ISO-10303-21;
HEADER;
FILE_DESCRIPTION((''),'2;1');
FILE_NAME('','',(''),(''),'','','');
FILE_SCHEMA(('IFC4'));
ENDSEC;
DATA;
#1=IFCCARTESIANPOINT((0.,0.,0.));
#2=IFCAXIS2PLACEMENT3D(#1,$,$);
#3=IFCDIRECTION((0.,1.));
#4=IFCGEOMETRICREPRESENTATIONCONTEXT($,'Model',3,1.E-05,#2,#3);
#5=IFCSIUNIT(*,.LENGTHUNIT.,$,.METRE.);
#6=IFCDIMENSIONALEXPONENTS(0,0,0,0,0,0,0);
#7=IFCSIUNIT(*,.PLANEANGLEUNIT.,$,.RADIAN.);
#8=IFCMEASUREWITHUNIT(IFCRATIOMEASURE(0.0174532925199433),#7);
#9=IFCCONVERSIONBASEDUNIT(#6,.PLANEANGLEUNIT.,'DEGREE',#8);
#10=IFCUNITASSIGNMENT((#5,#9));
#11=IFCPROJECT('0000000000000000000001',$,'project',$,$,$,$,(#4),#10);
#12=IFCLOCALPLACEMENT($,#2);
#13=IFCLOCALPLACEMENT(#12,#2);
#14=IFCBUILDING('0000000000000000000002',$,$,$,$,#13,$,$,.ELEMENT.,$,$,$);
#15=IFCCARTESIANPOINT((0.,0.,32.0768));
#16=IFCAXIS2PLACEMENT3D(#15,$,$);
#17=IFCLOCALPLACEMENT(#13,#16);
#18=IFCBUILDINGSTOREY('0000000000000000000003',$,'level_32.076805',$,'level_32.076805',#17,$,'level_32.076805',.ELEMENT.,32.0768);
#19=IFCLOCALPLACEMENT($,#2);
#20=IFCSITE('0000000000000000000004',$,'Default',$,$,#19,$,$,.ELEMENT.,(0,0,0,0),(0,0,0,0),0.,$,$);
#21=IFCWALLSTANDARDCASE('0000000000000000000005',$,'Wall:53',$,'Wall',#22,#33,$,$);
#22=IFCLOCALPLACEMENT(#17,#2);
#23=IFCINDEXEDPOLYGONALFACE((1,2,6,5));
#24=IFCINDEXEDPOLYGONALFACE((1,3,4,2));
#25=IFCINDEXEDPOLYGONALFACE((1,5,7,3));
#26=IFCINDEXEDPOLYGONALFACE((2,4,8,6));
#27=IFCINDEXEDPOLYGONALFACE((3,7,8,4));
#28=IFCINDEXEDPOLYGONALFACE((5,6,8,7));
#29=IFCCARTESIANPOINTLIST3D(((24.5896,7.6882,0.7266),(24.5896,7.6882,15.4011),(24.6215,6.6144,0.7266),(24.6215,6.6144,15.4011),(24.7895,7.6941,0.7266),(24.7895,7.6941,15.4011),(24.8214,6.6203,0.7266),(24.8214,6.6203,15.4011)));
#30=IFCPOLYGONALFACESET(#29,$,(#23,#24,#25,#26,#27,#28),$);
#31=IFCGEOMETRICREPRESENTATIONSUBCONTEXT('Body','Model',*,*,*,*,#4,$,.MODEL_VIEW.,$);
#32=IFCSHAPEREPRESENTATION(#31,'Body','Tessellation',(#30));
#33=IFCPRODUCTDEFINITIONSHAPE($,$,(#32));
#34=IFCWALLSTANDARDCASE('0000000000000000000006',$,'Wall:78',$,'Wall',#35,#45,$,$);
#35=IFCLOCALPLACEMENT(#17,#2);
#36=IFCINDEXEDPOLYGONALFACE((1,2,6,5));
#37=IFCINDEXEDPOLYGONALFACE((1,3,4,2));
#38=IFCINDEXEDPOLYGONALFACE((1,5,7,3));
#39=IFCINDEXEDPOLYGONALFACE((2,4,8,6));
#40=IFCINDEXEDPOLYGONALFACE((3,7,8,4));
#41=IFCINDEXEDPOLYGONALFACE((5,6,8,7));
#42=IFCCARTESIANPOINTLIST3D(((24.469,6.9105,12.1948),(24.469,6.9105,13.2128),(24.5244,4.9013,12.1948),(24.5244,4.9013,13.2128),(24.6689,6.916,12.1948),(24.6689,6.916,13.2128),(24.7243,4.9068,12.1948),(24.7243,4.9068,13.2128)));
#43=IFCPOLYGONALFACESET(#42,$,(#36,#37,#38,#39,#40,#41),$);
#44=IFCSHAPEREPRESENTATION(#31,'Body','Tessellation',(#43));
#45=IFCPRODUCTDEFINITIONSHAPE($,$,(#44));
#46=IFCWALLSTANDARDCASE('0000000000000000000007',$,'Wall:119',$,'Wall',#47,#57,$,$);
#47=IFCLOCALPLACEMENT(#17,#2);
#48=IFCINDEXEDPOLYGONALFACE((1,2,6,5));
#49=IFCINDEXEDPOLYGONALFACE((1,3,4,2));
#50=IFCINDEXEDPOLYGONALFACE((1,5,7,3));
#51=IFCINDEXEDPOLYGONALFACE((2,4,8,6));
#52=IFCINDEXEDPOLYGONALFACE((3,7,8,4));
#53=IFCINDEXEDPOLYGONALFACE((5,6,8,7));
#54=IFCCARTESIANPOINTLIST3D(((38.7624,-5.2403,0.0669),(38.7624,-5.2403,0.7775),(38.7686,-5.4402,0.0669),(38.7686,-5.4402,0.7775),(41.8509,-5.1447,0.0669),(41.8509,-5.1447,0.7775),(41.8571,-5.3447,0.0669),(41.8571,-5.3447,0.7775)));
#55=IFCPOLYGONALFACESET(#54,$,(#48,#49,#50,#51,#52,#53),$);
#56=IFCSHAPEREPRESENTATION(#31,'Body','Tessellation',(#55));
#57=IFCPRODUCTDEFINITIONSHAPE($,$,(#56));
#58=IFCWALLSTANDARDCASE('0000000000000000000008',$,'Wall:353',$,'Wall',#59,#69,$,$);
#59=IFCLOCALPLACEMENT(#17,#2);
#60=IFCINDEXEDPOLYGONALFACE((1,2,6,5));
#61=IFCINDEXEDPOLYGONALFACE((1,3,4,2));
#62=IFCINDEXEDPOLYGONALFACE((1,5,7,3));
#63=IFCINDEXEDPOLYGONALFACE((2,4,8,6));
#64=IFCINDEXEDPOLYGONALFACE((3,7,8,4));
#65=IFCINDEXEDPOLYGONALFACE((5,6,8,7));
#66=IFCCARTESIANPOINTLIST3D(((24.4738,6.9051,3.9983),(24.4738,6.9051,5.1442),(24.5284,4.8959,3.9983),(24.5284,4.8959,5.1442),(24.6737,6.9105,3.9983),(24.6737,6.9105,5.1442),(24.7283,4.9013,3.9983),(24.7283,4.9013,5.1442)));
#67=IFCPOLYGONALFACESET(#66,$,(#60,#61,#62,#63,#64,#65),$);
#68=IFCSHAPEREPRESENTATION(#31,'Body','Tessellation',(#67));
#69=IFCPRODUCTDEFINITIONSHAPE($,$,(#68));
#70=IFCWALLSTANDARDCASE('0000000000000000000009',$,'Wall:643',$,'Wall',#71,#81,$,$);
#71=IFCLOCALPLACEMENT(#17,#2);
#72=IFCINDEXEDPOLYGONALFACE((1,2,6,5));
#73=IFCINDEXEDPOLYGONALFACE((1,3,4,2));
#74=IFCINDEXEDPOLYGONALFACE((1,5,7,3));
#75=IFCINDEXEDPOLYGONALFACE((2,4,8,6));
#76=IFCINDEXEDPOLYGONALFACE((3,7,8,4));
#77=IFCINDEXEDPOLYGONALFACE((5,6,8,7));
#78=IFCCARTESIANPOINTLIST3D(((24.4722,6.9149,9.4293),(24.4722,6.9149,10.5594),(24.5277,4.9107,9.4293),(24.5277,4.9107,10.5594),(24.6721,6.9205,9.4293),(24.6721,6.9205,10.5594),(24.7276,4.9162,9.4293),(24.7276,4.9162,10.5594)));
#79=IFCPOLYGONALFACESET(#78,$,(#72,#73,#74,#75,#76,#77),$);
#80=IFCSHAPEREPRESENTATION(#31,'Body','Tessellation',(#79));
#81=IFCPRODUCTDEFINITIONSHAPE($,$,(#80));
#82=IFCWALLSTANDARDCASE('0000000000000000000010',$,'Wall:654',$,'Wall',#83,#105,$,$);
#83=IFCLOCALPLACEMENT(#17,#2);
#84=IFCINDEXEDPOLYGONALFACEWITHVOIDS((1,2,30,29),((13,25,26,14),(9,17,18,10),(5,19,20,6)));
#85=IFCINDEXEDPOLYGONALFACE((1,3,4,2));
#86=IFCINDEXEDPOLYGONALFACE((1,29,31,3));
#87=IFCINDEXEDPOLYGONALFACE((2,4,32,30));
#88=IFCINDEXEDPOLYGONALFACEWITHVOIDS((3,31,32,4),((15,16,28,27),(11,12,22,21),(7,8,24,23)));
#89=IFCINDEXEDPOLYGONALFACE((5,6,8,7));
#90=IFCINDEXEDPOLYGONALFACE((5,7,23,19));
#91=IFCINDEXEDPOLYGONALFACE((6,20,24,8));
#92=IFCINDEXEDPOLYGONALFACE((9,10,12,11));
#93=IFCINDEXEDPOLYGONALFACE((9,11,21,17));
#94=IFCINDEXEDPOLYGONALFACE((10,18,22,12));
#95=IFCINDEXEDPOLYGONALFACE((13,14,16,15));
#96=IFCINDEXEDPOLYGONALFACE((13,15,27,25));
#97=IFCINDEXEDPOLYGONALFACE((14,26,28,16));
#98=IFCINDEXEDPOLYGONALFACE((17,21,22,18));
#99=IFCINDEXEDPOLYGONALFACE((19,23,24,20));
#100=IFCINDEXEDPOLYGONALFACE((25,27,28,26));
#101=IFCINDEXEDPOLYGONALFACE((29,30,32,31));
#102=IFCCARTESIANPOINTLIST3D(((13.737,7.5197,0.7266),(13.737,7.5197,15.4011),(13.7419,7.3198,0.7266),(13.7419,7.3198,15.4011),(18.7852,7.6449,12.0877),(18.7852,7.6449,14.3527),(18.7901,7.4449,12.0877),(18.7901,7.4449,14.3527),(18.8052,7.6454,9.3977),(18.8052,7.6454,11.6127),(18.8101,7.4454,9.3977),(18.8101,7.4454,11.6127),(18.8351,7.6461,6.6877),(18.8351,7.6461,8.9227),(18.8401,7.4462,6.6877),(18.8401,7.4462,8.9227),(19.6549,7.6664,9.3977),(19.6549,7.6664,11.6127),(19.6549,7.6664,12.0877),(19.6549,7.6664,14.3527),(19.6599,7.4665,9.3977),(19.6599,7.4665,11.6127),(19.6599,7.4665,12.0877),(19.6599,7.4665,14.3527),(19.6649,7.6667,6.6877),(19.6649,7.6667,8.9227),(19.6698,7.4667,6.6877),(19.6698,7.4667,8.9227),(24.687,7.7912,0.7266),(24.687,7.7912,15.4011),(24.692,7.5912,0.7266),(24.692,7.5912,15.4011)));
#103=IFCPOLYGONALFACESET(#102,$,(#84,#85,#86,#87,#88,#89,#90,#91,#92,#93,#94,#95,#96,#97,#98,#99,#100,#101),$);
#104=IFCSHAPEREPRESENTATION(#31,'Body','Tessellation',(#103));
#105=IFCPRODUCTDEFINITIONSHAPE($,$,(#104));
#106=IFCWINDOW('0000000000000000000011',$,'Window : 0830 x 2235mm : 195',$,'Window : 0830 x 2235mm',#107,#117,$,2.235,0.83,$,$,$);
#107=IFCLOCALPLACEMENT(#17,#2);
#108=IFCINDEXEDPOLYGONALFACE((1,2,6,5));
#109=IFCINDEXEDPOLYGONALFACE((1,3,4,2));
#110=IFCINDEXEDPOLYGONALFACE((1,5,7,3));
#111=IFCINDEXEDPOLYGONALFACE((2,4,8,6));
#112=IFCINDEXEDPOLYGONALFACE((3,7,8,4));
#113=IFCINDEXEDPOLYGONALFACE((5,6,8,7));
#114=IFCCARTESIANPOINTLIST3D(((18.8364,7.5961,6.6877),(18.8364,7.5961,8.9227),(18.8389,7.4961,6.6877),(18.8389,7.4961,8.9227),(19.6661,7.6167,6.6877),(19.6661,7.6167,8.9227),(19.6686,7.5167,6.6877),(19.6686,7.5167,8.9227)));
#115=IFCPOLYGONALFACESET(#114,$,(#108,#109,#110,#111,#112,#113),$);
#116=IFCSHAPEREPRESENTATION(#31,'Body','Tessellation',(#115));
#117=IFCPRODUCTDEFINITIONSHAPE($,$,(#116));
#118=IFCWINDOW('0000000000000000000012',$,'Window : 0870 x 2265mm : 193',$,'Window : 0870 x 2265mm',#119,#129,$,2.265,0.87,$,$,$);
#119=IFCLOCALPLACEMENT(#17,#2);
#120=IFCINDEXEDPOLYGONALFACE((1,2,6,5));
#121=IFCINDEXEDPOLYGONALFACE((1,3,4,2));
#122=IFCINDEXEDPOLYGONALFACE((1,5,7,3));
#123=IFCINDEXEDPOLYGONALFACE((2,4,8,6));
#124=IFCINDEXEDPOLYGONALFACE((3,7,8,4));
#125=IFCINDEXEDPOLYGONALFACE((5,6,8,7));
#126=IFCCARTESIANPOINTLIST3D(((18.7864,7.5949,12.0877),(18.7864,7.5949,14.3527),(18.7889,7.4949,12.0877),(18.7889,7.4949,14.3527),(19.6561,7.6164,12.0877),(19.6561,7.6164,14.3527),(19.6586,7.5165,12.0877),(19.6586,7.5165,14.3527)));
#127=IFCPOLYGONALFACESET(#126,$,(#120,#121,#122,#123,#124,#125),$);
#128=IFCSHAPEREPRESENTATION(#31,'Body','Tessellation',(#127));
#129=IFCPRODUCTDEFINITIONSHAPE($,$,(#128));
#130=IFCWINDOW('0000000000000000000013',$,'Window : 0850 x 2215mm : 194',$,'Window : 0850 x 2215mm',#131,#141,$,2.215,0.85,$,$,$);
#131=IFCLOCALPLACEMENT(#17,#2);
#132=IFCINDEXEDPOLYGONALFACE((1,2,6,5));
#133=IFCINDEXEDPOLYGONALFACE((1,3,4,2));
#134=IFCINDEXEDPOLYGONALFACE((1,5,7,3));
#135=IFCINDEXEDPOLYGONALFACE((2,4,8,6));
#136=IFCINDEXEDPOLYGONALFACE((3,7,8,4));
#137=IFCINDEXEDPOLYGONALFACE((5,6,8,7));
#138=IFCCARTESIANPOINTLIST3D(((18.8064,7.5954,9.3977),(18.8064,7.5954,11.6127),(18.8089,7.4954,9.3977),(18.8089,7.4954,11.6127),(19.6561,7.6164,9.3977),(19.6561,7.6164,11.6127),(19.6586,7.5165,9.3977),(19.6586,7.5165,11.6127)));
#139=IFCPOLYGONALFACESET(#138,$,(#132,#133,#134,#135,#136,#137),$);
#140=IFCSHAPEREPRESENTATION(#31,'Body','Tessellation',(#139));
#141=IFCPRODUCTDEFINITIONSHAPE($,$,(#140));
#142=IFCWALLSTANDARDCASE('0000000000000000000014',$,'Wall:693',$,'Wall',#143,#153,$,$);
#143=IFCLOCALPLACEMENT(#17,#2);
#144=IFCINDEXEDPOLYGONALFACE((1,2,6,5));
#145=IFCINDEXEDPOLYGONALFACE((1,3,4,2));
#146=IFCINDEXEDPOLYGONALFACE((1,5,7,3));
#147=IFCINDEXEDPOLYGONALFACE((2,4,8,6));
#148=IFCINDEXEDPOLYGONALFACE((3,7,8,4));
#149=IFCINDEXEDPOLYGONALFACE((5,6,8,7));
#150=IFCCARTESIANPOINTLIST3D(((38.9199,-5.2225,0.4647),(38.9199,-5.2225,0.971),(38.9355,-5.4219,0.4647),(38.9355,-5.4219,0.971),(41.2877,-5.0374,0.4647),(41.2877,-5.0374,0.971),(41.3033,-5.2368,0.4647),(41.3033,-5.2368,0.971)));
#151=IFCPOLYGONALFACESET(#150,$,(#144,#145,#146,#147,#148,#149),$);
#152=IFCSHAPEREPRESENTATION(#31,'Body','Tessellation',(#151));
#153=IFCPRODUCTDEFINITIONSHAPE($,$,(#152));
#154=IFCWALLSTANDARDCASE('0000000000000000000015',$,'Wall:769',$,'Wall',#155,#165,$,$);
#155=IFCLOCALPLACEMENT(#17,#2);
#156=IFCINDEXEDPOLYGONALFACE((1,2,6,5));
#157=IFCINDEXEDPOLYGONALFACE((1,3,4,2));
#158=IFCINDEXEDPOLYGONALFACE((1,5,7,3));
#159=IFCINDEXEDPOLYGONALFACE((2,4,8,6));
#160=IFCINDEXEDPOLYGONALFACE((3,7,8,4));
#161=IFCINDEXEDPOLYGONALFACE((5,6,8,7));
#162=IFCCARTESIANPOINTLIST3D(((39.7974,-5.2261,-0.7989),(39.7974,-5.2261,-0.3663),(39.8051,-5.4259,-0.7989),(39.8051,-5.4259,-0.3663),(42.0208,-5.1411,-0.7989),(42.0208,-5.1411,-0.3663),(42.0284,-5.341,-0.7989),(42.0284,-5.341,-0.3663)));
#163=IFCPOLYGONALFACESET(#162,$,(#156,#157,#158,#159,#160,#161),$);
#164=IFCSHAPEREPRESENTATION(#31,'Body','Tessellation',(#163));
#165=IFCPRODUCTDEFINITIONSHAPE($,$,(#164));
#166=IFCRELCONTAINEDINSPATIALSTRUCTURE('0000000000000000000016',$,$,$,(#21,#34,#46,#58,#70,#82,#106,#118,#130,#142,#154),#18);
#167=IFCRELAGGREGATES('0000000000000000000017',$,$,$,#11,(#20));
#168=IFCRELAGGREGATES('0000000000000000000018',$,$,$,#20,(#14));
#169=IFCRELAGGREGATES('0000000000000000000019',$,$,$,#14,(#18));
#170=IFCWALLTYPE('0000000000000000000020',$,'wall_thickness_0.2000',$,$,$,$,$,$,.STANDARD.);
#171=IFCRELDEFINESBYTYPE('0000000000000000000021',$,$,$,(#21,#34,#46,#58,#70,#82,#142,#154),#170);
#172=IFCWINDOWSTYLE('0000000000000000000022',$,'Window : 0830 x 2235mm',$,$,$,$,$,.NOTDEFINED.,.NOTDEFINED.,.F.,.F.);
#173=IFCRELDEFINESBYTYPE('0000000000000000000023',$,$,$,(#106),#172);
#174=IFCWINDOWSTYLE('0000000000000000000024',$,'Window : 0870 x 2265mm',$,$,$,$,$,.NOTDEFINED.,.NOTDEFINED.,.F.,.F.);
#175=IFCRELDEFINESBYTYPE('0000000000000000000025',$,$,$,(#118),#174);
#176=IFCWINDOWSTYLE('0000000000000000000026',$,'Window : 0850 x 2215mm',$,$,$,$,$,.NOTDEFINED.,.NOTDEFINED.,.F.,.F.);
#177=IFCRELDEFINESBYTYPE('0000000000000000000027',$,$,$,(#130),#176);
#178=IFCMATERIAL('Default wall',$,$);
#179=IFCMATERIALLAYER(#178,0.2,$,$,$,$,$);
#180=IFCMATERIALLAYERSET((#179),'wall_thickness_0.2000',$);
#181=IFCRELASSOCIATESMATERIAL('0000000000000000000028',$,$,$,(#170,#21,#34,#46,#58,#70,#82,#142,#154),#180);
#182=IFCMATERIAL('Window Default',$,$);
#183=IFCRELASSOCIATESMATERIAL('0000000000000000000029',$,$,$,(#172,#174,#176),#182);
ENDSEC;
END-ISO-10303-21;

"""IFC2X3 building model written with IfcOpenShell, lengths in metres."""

from ifc_helpers import new_model, entity, si_unit, converted_unit, direction, frame, frame_2d, origin, origin_2d_with_axis, place, context, subcontext, project, spatial, polyline, rectangle, outline, extrude, source, transform, mapped, material, layer, layer_set, layer_usage, type_object, type_shapes, element, fill, save


model = new_model("IFC2X3")

# Units and contexts
model_context = context("Model", 3, precision=1e-05, world=origin(), true_north=direction((0.0, 1.0)))
body_context = subcontext(model_context, "Body", "Model", "MODEL_VIEW")
ifc_project = project(units=[si_unit("LENGTHUNIT", "METRE"), converted_unit("PLANEANGLEUNIT", "DEGREE", entity("IfcRatioMeasure", 0.0174532925199433), si_unit("PLANEANGLEUNIT", "RADIAN"), dimensions=[0, 0, 0, 0, 0, 0, 0])], contexts=[model_context])

# Site, building, storey
site_placement = place(None, origin())
site = spatial("IfcSite", under=ifc_project, at=site_placement, Name="Default", CompositionType="ELEMENT", RefLatitude=(0, 0, 0, 0), RefLongitude=(0, 0, 0, 0), RefElevation=0.0)
placement_1 = place(None, origin())
building_placement = place(placement_1, origin())
building = spatial("IfcBuilding", under=site, at=building_placement, CompositionType="ELEMENT")
storey_placement = place(building_placement, frame((0.0, 0.0, 32.0768)))
storey = spatial("IfcBuildingStorey", under=building, at=storey_placement, Name="level_32.076805", ObjectType="level_32.076805", LongName="level_32.076805", CompositionType="ELEMENT", Elevation=32.0768)

# Walls
ifc_material_1 = material(Name="Default wall")
ifc_layer = layer(ifc_material_1, 0.2)
ifc_layer_set = layer_set([ifc_layer], Name="wall_thickness_0.2000")
ifc_layer_usage = layer_usage(ifc_layer_set, "AXIS2", "POSITIVE", -0.1)
wall_type = type_object("IfcWallType", Name="wall_thickness_0.2000", PredefinedType="STANDARD", material=ifc_layer_set)
placement_2 = place(building_placement, frame((0.0, 0.0, 32.8034)))
wall_1_placement = place(placement_2, frame((24.6895, 7.6912, 0.0), z_axis=(0.0, 0.0, 1.0), x_axis=(0.029685, -0.999559, 0.0)))
element("IfcWallStandardCase", 1, at=wall_1_placement, inside=storey, type_object=wall_type, material=ifc_layer_usage, Name="Wall:53", ObjectType="Wall", context=body_context, shape_type="SweptSolid", body=[
    extrude(outline(polyline([(1.0743, -0.1), (1.0743, 0.1), (0.0, 0.1), (0.0, -0.1), (1.0743, -0.1)])), origin(), (0.0, 0.0, 1.0), 14.6745),
])
placement_3 = place(building_placement, frame((0.0, 0.0, 44.2716)))
wall_2_placement = place(placement_3, frame((24.6244, 4.904, 0.0), z_axis=(0.0, 0.0, 1.0), x_axis=(-0.027582, 0.99962, 0.0)))
element("IfcWallStandardCase", 2, at=wall_2_placement, inside=storey, type_object=wall_type, material=ifc_layer_usage, Name="Wall:78", ObjectType="Wall", context=body_context, shape_type="SweptSolid", body=[
    extrude(outline(polyline([(2.01, -0.1), (2.01, 0.1), (0.0, 0.1), (0.0, -0.1), (2.01, -0.1)])), origin(), (0.0, 0.0, 1.0), 1.018),
])
placement_4 = place(building_placement, frame((0.0, 0.0, 32.1437)))
wall_3_placement = place(placement_4, frame((38.7655, -5.3403, 0.0), z_axis=(0.0, 0.0, 1.0), x_axis=(0.999522, 0.030931, 0.0)))
element("IfcWallStandardCase", 3, at=wall_3_placement, inside=storey, type_object=wall_type, material=ifc_layer_usage, Name="Wall:119", ObjectType="Wall", context=body_context, shape_type="SweptSolid", body=[
    extrude(outline(polyline([(3.09, -0.1), (3.09, 0.1), (0.0, 0.1), (0.0, -0.1), (3.09, -0.1)])), origin(), (0.0, 0.0, 1.0), 0.7106),
])
placement_5 = place(building_placement, frame((0.0, 0.0, 36.0751)))
wall_4_placement = place(placement_5, frame((24.6283, 4.8986, 0.0), z_axis=(0.0, 0.0, 1.0), x_axis=(-0.027138, 0.999632, 0.0)))
element("IfcWallStandardCase", 4, at=wall_4_placement, inside=storey, type_object=wall_type, material=ifc_layer_usage, Name="Wall:353", ObjectType="Wall", context=body_context, shape_type="SweptSolid", body=[
    extrude(outline(polyline([(2.01, -0.1), (2.01, 0.1), (0.0, 0.1), (0.0, -0.1), (2.01, -0.1)])), origin(), (0.0, 0.0, 1.0), 1.1459),
])
placement_6 = place(building_placement, frame((0.0, 0.0, 41.5061)))
wall_5_placement = place(placement_6, frame((24.6277, 4.9135, 0.0), z_axis=(0.0, 0.0, 1.0), x_axis=(-0.027697, 0.999616, 0.0)))
element("IfcWallStandardCase", 5, at=wall_5_placement, inside=storey, type_object=wall_type, material=ifc_layer_usage, Name="Wall:643", ObjectType="Wall", context=body_context, shape_type="SweptSolid", body=[
    extrude(outline(polyline([(2.005, -0.1), (2.005, 0.1), (0.0, 0.1), (0.0, -0.1), (2.005, -0.1)])), origin(), (0.0, 0.0, 1.0), 1.1301),
])

# Wall, openings, windows
placement_7 = place(building_placement, frame((0.0, 0.0, 32.8034)))
wall_6_placement = place(placement_7, frame((24.6895, 7.6912, 0.0), z_axis=(0.0, 0.0, 1.0), x_axis=(-0.999693, -0.024779, 0.0)))
wall_6 = element("IfcWallStandardCase", 6, at=wall_6_placement, inside=storey, type_object=wall_type, material=ifc_layer_usage, Name="Wall:654", ObjectType="Wall", context=body_context, shape_type="SweptSolid", body=[
    extrude(outline(polyline([(10.9534, -0.1), (10.9534, 0.1), (0.0, 0.1), (0.0, -0.1), (10.9534, -0.1)])), origin(), (0.0, 0.0, 1.0), 14.6745),
])
opening_1_placement = place(wall_6_placement, frame((5.0337, -0.1, 11.3611)))
opening_1 = element("IfcOpeningElement", 7, at=opening_1_placement, cuts=wall_6, ObjectType="Opening", context=body_context, shape_type="SweptSolid", body=[
    extrude(rectangle(XDim=0.87, YDim=2.265, at=frame_2d((1.1325, 0.435), x_axis=(0.0, 1.0))), frame((0.0, 0.0, 0.0), z_axis=(0.0, 1.0, 0.0), x_axis=(0.0, 0.0, 1.0)), (0.0, 0.0, 1.0), 0.2),
])
opening_2_placement = place(wall_6_placement, frame((5.0337, -0.1, 8.6711)))
opening_2 = element("IfcOpeningElement", 8, at=opening_2_placement, cuts=wall_6, ObjectType="Opening", context=body_context, shape_type="SweptSolid", body=[
    extrude(rectangle(XDim=0.85, YDim=2.215, at=frame_2d((1.1075, 0.425), x_axis=(0.0, 1.0))), frame((0.0, 0.0, 0.0), z_axis=(0.0, 1.0, 0.0), x_axis=(0.0, 0.0, 1.0)), (0.0, 0.0, 1.0), 0.2),
])
opening_3_placement = place(wall_6_placement, frame((5.0237, -0.1, 5.9611)))
opening_3 = element("IfcOpeningElement", 9, at=opening_3_placement, cuts=wall_6, ObjectType="Opening", context=body_context, shape_type="SweptSolid", body=[
    extrude(rectangle(XDim=0.83, YDim=2.235, at=frame_2d((1.1175, 0.415), x_axis=(0.0, 1.0))), frame((0.0, 0.0, 0.0), z_axis=(0.0, 1.0, 0.0), x_axis=(0.0, 0.0, 1.0)), (0.0, 0.0, 1.0), 0.2),
])
ifc_material_2 = material(Name="Window Default")
window_style_1 = type_object("IfcWindowStyle", Name="Window : 0830 x 2235mm", ConstructionType="NOTDEFINED", OperationType="NOTDEFINED", ParameterTakesPrecedence=False, Sizeable=False, material=ifc_material_2)
shared_shape_1 = source(origin(), body_context, "Body", "SweptSolid", [
    extrude(rectangle(XDim=0.1, YDim=0.83, at=origin_2d_with_axis()), frame((0.415, 0.1, 0.0), z_axis=(0.0, 0.0, 1.0), x_axis=(0.0, 1.0, 0.0)), (0.0, 0.0, 1.0), 2.235),
])
type_shapes(window_style_1, [shared_shape_1])
window_1_placement = place(opening_3_placement, origin())
window_1 = element("IfcWindow", 10, at=window_1_placement, inside=storey, type_object=window_style_1, Name="Window : 0830 x 2235mm : 195", ObjectType="Window : 0830 x 2235mm", OverallHeight=2.235, OverallWidth=0.83, context=body_context, shape_type="MappedRepresentation", body=[
    mapped(shared_shape_1, transform((0.0, 0.0, 0.0), scale=1.0)),
])
fill(opening_3, window_1)
window_style_2 = type_object("IfcWindowStyle", Name="Window : 0870 x 2265mm", ConstructionType="NOTDEFINED", OperationType="NOTDEFINED", ParameterTakesPrecedence=False, Sizeable=False, material=ifc_material_2)
shared_shape_2 = source(origin(), body_context, "Body", "SweptSolid", [
    extrude(rectangle(XDim=0.1, YDim=0.87, at=origin_2d_with_axis()), frame((0.435, 0.1, 0.0), z_axis=(0.0, 0.0, 1.0), x_axis=(0.0, 1.0, 0.0)), (0.0, 0.0, 1.0), 2.265),
])
type_shapes(window_style_2, [shared_shape_2])
window_2_placement = place(opening_1_placement, origin())
window_2 = element("IfcWindow", 11, at=window_2_placement, inside=storey, type_object=window_style_2, Name="Window : 0870 x 2265mm : 193", ObjectType="Window : 0870 x 2265mm", OverallHeight=2.265, OverallWidth=0.87, context=body_context, shape_type="MappedRepresentation", body=[
    mapped(shared_shape_2, transform((0.0, 0.0, 0.0), scale=1.0)),
])
fill(opening_1, window_2)
window_style_3 = type_object("IfcWindowStyle", Name="Window : 0850 x 2215mm", ConstructionType="NOTDEFINED", OperationType="NOTDEFINED", ParameterTakesPrecedence=False, Sizeable=False, material=ifc_material_2)
shared_shape_3 = source(origin(), body_context, "Body", "SweptSolid", [
    extrude(rectangle(XDim=0.1, YDim=0.85, at=origin_2d_with_axis()), frame((0.425, 0.1, 0.0), z_axis=(0.0, 0.0, 1.0), x_axis=(0.0, 1.0, 0.0)), (0.0, 0.0, 1.0), 2.215),
])
type_shapes(window_style_3, [shared_shape_3])
window_3_placement = place(opening_2_placement, origin())
window_3 = element("IfcWindow", 12, at=window_3_placement, inside=storey, type_object=window_style_3, Name="Window : 0850 x 2215mm : 194", ObjectType="Window : 0850 x 2215mm", OverallHeight=2.215, OverallWidth=0.85, context=body_context, shape_type="MappedRepresentation", body=[
    mapped(shared_shape_3, transform((0.0, 0.0, 0.0), scale=1.0)),
])
fill(opening_2, window_3)

# Walls
placement_8 = place(building_placement, frame((0.0, 0.0, 32.5415)))
wall_7_placement = place(placement_8, frame((38.9277, -5.3222, 0.0), z_axis=(0.0, 0.0, 1.0), x_axis=(0.996958, 0.077942, 0.0)))
element("IfcWallStandardCase", 13, at=wall_7_placement, inside=storey, type_object=wall_type, material=ifc_layer_usage, Name="Wall:693", ObjectType="Wall", context=body_context, shape_type="SweptSolid", body=[
    extrude(outline(polyline([(2.375, -0.1), (2.375, 0.1), (0.0, 0.1), (0.0, -0.1), (2.375, -0.1)])), origin(), (0.0, 0.0, 1.0), 0.5063),
])
placement_9 = place(building_placement, frame((0.0, 0.0, 31.2779)))
wall_8_placement = place(placement_9, frame((39.8012, -5.326, 0.0), z_axis=(0.0, 0.0, 1.0), x_axis=(0.999271, 0.038188, 0.0)))
element("IfcWallStandardCase", 14, at=wall_8_placement, inside=storey, type_object=wall_type, material=ifc_layer_usage, Name="Wall:769", ObjectType="Wall", context=body_context, shape_type="SweptSolid", body=[
    extrude(outline(polyline([(2.225, -0.1), (2.225, 0.1), (0.0, 0.1), (0.0, -0.1), (2.225, -0.1)])), origin(), (0.0, 0.0, 1.0), 0.4325),
])

save(model, "model.ifc")
